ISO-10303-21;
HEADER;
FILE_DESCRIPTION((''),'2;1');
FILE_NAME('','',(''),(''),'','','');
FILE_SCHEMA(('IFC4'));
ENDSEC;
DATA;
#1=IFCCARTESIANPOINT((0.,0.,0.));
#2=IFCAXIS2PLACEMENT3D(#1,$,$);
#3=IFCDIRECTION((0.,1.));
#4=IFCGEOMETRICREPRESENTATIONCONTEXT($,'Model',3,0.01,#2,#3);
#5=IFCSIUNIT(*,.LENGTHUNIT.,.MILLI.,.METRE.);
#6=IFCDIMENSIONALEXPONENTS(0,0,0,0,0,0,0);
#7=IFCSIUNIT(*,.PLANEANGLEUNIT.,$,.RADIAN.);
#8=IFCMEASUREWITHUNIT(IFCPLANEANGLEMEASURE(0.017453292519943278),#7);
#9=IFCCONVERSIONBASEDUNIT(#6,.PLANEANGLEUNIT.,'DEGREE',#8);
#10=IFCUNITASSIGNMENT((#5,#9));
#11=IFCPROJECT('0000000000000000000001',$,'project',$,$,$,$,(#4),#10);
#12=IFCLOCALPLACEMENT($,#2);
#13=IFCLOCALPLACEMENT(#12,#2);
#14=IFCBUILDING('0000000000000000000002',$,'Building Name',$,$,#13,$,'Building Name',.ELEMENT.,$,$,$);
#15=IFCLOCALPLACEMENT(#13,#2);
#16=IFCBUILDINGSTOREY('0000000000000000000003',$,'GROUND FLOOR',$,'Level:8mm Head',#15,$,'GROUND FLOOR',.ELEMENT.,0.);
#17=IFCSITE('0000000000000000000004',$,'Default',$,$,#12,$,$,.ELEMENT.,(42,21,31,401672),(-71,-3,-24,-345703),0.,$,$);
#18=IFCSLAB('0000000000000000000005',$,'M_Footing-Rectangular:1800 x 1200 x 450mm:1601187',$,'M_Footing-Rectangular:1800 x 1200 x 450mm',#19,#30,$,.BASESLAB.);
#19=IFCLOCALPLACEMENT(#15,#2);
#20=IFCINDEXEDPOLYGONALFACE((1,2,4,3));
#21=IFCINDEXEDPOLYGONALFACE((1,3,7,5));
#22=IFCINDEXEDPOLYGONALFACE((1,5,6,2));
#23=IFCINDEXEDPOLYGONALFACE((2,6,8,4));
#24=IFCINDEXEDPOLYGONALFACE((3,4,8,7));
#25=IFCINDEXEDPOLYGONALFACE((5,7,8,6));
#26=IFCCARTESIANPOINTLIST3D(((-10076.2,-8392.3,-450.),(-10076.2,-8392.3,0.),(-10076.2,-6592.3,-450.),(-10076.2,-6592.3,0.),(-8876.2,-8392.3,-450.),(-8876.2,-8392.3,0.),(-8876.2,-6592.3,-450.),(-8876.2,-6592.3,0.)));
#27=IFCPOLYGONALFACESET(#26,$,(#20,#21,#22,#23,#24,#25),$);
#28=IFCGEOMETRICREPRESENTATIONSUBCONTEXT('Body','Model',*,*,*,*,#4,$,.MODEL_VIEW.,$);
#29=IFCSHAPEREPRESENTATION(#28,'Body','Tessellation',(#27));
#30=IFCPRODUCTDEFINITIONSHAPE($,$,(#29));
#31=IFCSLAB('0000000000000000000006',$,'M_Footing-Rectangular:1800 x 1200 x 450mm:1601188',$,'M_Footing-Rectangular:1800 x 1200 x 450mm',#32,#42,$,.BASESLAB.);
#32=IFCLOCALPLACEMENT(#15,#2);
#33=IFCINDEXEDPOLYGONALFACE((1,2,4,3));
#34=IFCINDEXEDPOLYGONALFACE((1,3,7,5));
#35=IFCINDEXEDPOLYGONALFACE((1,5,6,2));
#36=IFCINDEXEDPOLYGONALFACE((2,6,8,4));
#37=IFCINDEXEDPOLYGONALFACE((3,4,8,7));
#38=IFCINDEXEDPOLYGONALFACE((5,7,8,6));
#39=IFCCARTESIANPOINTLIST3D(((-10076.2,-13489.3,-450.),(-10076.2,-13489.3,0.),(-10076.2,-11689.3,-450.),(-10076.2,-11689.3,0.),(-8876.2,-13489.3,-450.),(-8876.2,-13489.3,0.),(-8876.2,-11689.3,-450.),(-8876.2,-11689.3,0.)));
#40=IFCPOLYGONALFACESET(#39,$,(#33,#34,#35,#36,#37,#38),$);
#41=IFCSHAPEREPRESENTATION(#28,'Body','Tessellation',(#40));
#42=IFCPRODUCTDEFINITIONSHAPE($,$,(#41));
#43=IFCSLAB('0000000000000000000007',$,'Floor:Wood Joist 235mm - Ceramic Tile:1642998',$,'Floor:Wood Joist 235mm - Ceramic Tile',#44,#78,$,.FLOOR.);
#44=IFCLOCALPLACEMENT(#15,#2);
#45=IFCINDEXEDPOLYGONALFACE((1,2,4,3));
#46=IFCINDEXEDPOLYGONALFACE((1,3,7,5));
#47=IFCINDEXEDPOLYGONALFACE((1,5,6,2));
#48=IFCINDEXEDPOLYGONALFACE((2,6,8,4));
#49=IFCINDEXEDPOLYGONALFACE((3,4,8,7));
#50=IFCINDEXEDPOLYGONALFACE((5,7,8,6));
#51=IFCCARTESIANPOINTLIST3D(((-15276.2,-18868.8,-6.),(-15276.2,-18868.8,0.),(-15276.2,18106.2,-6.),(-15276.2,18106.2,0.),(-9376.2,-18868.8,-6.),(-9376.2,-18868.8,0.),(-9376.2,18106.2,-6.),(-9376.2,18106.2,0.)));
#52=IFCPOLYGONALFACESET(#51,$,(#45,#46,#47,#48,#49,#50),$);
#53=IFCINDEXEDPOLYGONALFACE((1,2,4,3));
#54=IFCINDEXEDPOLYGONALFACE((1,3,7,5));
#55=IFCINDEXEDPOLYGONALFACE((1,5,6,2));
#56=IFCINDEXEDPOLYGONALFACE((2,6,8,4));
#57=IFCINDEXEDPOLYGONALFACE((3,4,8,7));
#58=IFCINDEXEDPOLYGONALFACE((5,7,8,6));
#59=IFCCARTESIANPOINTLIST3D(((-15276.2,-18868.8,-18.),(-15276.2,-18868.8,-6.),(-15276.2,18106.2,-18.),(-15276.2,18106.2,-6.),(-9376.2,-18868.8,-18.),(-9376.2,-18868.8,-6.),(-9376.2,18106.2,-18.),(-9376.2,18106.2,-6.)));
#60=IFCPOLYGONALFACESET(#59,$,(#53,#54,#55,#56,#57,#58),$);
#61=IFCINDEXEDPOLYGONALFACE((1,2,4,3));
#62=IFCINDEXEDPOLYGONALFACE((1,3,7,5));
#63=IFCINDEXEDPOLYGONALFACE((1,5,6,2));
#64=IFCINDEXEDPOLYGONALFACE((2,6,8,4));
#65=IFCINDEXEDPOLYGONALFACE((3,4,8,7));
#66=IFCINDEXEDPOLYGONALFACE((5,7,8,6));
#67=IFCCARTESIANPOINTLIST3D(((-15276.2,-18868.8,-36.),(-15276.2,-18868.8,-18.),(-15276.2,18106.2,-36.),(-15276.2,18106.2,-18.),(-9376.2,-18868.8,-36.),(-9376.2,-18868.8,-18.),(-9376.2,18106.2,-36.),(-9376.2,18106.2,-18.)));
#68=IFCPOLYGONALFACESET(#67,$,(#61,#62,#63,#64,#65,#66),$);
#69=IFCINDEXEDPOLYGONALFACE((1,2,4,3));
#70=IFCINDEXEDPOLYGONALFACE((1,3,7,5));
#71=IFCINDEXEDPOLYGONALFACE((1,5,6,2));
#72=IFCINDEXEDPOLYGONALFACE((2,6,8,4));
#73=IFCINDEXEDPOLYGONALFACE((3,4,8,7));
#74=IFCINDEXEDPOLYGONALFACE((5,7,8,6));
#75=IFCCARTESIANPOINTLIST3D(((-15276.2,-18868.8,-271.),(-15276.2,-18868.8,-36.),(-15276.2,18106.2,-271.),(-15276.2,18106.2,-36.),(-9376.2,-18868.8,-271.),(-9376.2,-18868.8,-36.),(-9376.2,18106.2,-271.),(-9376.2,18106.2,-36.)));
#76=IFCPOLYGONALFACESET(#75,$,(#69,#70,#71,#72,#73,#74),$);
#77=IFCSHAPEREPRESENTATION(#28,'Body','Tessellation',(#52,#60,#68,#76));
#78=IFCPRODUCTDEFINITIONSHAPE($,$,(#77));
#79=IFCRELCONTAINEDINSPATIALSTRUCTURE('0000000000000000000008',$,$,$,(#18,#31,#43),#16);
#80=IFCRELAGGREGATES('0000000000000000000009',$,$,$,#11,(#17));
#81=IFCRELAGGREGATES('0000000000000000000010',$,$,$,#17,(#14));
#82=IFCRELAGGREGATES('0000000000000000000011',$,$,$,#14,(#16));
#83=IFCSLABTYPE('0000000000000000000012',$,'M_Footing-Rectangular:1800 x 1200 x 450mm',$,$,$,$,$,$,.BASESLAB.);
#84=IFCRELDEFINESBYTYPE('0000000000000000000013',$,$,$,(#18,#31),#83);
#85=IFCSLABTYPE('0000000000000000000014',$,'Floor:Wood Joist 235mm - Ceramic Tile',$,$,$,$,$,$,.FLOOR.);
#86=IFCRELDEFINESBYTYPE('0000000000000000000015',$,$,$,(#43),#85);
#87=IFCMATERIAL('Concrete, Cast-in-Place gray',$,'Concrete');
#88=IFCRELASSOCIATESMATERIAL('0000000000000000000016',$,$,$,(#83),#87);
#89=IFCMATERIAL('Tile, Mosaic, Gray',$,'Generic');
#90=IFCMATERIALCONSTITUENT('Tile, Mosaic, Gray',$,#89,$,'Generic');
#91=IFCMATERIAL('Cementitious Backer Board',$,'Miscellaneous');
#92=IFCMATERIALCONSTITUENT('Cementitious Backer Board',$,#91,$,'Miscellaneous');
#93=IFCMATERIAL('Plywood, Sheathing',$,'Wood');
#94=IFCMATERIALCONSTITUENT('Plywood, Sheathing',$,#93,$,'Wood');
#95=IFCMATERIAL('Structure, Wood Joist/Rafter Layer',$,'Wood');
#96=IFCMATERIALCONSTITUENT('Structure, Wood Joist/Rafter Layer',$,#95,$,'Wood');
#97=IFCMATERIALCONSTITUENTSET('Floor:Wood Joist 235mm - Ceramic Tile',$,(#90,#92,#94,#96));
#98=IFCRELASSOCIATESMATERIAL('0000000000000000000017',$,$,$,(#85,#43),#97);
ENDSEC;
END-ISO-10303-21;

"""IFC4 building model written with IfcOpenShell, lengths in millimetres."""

from ifc_helpers import new_model, entity, si_unit, converted_unit, direction, frame, origin, place, context, subcontext, project, spatial, indexed_curve, outline, extrude, material, constituent, constituent_set, type_object, element, save


model = new_model("IFC4")

# Units and contexts
model_context = context("Model", 3, precision=0.01, world=origin(), true_north=direction((0.0, 1.0)))
body_context = subcontext(model_context, "Body", "Model", "MODEL_VIEW")
ifc_project = project(units=[si_unit("LENGTHUNIT", "METRE", prefix="MILLI"), converted_unit("PLANEANGLEUNIT", "DEGREE", entity("IfcPlaneAngleMeasure", 0.017453292519943278), si_unit("PLANEANGLEUNIT", "RADIAN"), dimensions=[0, 0, 0, 0, 0, 0, 0])], contexts=[model_context])

# Site, building, storey
site_placement = place(None, origin())
site = spatial("IfcSite", under=ifc_project, at=site_placement, Name="Default", CompositionType="ELEMENT", RefLatitude=(42, 21, 31, 401672), RefLongitude=(-71, -3, -24, -345703), RefElevation=0.0)
building_placement = place(site_placement, origin())
building = spatial("IfcBuilding", under=site, at=building_placement, Name="Building Name", LongName="Building Name", CompositionType="ELEMENT")
storey_placement = place(building_placement, origin())
storey = spatial("IfcBuildingStorey", under=building, at=storey_placement, Name="GROUND FLOOR", ObjectType="Level:8mm Head", LongName="GROUND FLOOR", CompositionType="ELEMENT", Elevation=0.0)

# Shared definitions
ifc_material_1 = material(Name="Concrete, Cast-in-Place gray", Category="Concrete")

# Slabs
slab_type_1 = type_object("IfcSlabType", Name="M_Footing-Rectangular:1800 x 1200 x 450mm", PredefinedType="BASESLAB", material=ifc_material_1)
slab_1_placement = place(storey_placement, origin())
element("IfcSlab", 1, at=slab_1_placement, inside=storey, type_object=slab_type_1, Name="M_Footing-Rectangular:1800 x 1200 x 450mm:1601187", ObjectType="M_Footing-Rectangular:1800 x 1200 x 450mm", PredefinedType="BASESLAB", context=body_context, shape_type="SweptSolid", body=[
    extrude(outline(indexed_curve([(-600.0, -900.0), (600.0, -900.0), (600.0, 900.0), (-600.0, 900.0), (-600.0, -900.0)], self_intersect=False)), frame((-9476.2, -7492.3, -450.0), z_axis=(0.0, 0.0, 1.0), x_axis=(-1.0, 0.0, 0.0)), (0.0, 0.0, 1.0), 450.0),
])
slab_2_placement = place(storey_placement, origin())
element("IfcSlab", 2, at=slab_2_placement, inside=storey, type_object=slab_type_1, Name="M_Footing-Rectangular:1800 x 1200 x 450mm:1601188", ObjectType="M_Footing-Rectangular:1800 x 1200 x 450mm", PredefinedType="BASESLAB", context=body_context, shape_type="SweptSolid", body=[
    extrude(outline(indexed_curve([(-600.0, -900.0), (600.0, -900.0), (600.0, 900.0), (-600.0, 900.0), (-600.0, -900.0)], self_intersect=False)), frame((-9476.2, -12589.3, -450.0), z_axis=(0.0, 0.0, 1.0), x_axis=(-1.0, 0.0, 0.0)), (0.0, 0.0, 1.0), 450.0),
])
ifc_material_2 = material(Name="Tile, Mosaic, Gray", Category="Generic")
ifc_constituent_1 = constituent(ifc_material_2, Name="Tile, Mosaic, Gray", Category="Generic")
ifc_material_3 = material(Name="Cementitious Backer Board", Category="Miscellaneous")
ifc_constituent_2 = constituent(ifc_material_3, Name="Cementitious Backer Board", Category="Miscellaneous")
ifc_material_4 = material(Name="Plywood, Sheathing", Category="Wood")
ifc_constituent_3 = constituent(ifc_material_4, Name="Plywood, Sheathing", Category="Wood")
ifc_material_5 = material(Name="Structure, Wood Joist/Rafter Layer", Category="Wood")
ifc_constituent_4 = constituent(ifc_material_5, Name="Structure, Wood Joist/Rafter Layer", Category="Wood")
ifc_constituent_set = constituent_set(constituents=[ifc_constituent_1, ifc_constituent_2, ifc_constituent_3, ifc_constituent_4], Name="Floor:Wood Joist 235mm - Ceramic Tile")
slab_type_2 = type_object("IfcSlabType", Name="Floor:Wood Joist 235mm - Ceramic Tile", PredefinedType="FLOOR", material=ifc_constituent_set)
slab_3_placement = place(storey_placement, origin())
element("IfcSlab", 3, at=slab_3_placement, inside=storey, type_object=slab_type_2, material=ifc_constituent_set, Name="Floor:Wood Joist 235mm - Ceramic Tile:1642998", ObjectType="Floor:Wood Joist 235mm - Ceramic Tile", PredefinedType="FLOOR", context=body_context, shape_type="SweptSolid", body=[
    extrude(outline(indexed_curve([(-2950.0, -18487.5), (2950.0, -18487.5), (2950.0, 18487.5), (-2950.0, 18487.5), (-2950.0, -18487.5)], self_intersect=False)), frame((-12326.2, -381.3, -6.0), z_axis=(0.0, 0.0, 1.0), x_axis=(-1.0, 0.0, 0.0)), (0.0, 0.0, 1.0), 6.0),
    extrude(outline(indexed_curve([(-2950.0, -18487.5), (2950.0, -18487.5), (2950.0, 18487.5), (-2950.0, 18487.5), (-2950.0, -18487.5)], self_intersect=False)), frame((-12326.2, -381.3, -18.0), z_axis=(0.0, 0.0, 1.0), x_axis=(-1.0, 0.0, 0.0)), (0.0, 0.0, 1.0), 12.0),
    extrude(outline(indexed_curve([(-2950.0, -18487.5), (2950.0, -18487.5), (2950.0, 18487.5), (-2950.0, 18487.5), (-2950.0, -18487.5)], self_intersect=False)), frame((-12326.2, -381.3, -36.0), z_axis=(0.0, 0.0, 1.0), x_axis=(-1.0, 0.0, 0.0)), (0.0, 0.0, 1.0), 18.0),
    extrude(outline(indexed_curve([(-2950.0, -18487.5), (2950.0, -18487.5), (2950.0, 18487.5), (-2950.0, 18487.5), (-2950.0, -18487.5)], self_intersect=False)), frame((-12326.2, -381.3, -271.0), z_axis=(0.0, 0.0, 1.0), x_axis=(-1.0, 0.0, 0.0)), (0.0, 0.0, 1.0), 235.0),
])

save(model, "model.ifc")
